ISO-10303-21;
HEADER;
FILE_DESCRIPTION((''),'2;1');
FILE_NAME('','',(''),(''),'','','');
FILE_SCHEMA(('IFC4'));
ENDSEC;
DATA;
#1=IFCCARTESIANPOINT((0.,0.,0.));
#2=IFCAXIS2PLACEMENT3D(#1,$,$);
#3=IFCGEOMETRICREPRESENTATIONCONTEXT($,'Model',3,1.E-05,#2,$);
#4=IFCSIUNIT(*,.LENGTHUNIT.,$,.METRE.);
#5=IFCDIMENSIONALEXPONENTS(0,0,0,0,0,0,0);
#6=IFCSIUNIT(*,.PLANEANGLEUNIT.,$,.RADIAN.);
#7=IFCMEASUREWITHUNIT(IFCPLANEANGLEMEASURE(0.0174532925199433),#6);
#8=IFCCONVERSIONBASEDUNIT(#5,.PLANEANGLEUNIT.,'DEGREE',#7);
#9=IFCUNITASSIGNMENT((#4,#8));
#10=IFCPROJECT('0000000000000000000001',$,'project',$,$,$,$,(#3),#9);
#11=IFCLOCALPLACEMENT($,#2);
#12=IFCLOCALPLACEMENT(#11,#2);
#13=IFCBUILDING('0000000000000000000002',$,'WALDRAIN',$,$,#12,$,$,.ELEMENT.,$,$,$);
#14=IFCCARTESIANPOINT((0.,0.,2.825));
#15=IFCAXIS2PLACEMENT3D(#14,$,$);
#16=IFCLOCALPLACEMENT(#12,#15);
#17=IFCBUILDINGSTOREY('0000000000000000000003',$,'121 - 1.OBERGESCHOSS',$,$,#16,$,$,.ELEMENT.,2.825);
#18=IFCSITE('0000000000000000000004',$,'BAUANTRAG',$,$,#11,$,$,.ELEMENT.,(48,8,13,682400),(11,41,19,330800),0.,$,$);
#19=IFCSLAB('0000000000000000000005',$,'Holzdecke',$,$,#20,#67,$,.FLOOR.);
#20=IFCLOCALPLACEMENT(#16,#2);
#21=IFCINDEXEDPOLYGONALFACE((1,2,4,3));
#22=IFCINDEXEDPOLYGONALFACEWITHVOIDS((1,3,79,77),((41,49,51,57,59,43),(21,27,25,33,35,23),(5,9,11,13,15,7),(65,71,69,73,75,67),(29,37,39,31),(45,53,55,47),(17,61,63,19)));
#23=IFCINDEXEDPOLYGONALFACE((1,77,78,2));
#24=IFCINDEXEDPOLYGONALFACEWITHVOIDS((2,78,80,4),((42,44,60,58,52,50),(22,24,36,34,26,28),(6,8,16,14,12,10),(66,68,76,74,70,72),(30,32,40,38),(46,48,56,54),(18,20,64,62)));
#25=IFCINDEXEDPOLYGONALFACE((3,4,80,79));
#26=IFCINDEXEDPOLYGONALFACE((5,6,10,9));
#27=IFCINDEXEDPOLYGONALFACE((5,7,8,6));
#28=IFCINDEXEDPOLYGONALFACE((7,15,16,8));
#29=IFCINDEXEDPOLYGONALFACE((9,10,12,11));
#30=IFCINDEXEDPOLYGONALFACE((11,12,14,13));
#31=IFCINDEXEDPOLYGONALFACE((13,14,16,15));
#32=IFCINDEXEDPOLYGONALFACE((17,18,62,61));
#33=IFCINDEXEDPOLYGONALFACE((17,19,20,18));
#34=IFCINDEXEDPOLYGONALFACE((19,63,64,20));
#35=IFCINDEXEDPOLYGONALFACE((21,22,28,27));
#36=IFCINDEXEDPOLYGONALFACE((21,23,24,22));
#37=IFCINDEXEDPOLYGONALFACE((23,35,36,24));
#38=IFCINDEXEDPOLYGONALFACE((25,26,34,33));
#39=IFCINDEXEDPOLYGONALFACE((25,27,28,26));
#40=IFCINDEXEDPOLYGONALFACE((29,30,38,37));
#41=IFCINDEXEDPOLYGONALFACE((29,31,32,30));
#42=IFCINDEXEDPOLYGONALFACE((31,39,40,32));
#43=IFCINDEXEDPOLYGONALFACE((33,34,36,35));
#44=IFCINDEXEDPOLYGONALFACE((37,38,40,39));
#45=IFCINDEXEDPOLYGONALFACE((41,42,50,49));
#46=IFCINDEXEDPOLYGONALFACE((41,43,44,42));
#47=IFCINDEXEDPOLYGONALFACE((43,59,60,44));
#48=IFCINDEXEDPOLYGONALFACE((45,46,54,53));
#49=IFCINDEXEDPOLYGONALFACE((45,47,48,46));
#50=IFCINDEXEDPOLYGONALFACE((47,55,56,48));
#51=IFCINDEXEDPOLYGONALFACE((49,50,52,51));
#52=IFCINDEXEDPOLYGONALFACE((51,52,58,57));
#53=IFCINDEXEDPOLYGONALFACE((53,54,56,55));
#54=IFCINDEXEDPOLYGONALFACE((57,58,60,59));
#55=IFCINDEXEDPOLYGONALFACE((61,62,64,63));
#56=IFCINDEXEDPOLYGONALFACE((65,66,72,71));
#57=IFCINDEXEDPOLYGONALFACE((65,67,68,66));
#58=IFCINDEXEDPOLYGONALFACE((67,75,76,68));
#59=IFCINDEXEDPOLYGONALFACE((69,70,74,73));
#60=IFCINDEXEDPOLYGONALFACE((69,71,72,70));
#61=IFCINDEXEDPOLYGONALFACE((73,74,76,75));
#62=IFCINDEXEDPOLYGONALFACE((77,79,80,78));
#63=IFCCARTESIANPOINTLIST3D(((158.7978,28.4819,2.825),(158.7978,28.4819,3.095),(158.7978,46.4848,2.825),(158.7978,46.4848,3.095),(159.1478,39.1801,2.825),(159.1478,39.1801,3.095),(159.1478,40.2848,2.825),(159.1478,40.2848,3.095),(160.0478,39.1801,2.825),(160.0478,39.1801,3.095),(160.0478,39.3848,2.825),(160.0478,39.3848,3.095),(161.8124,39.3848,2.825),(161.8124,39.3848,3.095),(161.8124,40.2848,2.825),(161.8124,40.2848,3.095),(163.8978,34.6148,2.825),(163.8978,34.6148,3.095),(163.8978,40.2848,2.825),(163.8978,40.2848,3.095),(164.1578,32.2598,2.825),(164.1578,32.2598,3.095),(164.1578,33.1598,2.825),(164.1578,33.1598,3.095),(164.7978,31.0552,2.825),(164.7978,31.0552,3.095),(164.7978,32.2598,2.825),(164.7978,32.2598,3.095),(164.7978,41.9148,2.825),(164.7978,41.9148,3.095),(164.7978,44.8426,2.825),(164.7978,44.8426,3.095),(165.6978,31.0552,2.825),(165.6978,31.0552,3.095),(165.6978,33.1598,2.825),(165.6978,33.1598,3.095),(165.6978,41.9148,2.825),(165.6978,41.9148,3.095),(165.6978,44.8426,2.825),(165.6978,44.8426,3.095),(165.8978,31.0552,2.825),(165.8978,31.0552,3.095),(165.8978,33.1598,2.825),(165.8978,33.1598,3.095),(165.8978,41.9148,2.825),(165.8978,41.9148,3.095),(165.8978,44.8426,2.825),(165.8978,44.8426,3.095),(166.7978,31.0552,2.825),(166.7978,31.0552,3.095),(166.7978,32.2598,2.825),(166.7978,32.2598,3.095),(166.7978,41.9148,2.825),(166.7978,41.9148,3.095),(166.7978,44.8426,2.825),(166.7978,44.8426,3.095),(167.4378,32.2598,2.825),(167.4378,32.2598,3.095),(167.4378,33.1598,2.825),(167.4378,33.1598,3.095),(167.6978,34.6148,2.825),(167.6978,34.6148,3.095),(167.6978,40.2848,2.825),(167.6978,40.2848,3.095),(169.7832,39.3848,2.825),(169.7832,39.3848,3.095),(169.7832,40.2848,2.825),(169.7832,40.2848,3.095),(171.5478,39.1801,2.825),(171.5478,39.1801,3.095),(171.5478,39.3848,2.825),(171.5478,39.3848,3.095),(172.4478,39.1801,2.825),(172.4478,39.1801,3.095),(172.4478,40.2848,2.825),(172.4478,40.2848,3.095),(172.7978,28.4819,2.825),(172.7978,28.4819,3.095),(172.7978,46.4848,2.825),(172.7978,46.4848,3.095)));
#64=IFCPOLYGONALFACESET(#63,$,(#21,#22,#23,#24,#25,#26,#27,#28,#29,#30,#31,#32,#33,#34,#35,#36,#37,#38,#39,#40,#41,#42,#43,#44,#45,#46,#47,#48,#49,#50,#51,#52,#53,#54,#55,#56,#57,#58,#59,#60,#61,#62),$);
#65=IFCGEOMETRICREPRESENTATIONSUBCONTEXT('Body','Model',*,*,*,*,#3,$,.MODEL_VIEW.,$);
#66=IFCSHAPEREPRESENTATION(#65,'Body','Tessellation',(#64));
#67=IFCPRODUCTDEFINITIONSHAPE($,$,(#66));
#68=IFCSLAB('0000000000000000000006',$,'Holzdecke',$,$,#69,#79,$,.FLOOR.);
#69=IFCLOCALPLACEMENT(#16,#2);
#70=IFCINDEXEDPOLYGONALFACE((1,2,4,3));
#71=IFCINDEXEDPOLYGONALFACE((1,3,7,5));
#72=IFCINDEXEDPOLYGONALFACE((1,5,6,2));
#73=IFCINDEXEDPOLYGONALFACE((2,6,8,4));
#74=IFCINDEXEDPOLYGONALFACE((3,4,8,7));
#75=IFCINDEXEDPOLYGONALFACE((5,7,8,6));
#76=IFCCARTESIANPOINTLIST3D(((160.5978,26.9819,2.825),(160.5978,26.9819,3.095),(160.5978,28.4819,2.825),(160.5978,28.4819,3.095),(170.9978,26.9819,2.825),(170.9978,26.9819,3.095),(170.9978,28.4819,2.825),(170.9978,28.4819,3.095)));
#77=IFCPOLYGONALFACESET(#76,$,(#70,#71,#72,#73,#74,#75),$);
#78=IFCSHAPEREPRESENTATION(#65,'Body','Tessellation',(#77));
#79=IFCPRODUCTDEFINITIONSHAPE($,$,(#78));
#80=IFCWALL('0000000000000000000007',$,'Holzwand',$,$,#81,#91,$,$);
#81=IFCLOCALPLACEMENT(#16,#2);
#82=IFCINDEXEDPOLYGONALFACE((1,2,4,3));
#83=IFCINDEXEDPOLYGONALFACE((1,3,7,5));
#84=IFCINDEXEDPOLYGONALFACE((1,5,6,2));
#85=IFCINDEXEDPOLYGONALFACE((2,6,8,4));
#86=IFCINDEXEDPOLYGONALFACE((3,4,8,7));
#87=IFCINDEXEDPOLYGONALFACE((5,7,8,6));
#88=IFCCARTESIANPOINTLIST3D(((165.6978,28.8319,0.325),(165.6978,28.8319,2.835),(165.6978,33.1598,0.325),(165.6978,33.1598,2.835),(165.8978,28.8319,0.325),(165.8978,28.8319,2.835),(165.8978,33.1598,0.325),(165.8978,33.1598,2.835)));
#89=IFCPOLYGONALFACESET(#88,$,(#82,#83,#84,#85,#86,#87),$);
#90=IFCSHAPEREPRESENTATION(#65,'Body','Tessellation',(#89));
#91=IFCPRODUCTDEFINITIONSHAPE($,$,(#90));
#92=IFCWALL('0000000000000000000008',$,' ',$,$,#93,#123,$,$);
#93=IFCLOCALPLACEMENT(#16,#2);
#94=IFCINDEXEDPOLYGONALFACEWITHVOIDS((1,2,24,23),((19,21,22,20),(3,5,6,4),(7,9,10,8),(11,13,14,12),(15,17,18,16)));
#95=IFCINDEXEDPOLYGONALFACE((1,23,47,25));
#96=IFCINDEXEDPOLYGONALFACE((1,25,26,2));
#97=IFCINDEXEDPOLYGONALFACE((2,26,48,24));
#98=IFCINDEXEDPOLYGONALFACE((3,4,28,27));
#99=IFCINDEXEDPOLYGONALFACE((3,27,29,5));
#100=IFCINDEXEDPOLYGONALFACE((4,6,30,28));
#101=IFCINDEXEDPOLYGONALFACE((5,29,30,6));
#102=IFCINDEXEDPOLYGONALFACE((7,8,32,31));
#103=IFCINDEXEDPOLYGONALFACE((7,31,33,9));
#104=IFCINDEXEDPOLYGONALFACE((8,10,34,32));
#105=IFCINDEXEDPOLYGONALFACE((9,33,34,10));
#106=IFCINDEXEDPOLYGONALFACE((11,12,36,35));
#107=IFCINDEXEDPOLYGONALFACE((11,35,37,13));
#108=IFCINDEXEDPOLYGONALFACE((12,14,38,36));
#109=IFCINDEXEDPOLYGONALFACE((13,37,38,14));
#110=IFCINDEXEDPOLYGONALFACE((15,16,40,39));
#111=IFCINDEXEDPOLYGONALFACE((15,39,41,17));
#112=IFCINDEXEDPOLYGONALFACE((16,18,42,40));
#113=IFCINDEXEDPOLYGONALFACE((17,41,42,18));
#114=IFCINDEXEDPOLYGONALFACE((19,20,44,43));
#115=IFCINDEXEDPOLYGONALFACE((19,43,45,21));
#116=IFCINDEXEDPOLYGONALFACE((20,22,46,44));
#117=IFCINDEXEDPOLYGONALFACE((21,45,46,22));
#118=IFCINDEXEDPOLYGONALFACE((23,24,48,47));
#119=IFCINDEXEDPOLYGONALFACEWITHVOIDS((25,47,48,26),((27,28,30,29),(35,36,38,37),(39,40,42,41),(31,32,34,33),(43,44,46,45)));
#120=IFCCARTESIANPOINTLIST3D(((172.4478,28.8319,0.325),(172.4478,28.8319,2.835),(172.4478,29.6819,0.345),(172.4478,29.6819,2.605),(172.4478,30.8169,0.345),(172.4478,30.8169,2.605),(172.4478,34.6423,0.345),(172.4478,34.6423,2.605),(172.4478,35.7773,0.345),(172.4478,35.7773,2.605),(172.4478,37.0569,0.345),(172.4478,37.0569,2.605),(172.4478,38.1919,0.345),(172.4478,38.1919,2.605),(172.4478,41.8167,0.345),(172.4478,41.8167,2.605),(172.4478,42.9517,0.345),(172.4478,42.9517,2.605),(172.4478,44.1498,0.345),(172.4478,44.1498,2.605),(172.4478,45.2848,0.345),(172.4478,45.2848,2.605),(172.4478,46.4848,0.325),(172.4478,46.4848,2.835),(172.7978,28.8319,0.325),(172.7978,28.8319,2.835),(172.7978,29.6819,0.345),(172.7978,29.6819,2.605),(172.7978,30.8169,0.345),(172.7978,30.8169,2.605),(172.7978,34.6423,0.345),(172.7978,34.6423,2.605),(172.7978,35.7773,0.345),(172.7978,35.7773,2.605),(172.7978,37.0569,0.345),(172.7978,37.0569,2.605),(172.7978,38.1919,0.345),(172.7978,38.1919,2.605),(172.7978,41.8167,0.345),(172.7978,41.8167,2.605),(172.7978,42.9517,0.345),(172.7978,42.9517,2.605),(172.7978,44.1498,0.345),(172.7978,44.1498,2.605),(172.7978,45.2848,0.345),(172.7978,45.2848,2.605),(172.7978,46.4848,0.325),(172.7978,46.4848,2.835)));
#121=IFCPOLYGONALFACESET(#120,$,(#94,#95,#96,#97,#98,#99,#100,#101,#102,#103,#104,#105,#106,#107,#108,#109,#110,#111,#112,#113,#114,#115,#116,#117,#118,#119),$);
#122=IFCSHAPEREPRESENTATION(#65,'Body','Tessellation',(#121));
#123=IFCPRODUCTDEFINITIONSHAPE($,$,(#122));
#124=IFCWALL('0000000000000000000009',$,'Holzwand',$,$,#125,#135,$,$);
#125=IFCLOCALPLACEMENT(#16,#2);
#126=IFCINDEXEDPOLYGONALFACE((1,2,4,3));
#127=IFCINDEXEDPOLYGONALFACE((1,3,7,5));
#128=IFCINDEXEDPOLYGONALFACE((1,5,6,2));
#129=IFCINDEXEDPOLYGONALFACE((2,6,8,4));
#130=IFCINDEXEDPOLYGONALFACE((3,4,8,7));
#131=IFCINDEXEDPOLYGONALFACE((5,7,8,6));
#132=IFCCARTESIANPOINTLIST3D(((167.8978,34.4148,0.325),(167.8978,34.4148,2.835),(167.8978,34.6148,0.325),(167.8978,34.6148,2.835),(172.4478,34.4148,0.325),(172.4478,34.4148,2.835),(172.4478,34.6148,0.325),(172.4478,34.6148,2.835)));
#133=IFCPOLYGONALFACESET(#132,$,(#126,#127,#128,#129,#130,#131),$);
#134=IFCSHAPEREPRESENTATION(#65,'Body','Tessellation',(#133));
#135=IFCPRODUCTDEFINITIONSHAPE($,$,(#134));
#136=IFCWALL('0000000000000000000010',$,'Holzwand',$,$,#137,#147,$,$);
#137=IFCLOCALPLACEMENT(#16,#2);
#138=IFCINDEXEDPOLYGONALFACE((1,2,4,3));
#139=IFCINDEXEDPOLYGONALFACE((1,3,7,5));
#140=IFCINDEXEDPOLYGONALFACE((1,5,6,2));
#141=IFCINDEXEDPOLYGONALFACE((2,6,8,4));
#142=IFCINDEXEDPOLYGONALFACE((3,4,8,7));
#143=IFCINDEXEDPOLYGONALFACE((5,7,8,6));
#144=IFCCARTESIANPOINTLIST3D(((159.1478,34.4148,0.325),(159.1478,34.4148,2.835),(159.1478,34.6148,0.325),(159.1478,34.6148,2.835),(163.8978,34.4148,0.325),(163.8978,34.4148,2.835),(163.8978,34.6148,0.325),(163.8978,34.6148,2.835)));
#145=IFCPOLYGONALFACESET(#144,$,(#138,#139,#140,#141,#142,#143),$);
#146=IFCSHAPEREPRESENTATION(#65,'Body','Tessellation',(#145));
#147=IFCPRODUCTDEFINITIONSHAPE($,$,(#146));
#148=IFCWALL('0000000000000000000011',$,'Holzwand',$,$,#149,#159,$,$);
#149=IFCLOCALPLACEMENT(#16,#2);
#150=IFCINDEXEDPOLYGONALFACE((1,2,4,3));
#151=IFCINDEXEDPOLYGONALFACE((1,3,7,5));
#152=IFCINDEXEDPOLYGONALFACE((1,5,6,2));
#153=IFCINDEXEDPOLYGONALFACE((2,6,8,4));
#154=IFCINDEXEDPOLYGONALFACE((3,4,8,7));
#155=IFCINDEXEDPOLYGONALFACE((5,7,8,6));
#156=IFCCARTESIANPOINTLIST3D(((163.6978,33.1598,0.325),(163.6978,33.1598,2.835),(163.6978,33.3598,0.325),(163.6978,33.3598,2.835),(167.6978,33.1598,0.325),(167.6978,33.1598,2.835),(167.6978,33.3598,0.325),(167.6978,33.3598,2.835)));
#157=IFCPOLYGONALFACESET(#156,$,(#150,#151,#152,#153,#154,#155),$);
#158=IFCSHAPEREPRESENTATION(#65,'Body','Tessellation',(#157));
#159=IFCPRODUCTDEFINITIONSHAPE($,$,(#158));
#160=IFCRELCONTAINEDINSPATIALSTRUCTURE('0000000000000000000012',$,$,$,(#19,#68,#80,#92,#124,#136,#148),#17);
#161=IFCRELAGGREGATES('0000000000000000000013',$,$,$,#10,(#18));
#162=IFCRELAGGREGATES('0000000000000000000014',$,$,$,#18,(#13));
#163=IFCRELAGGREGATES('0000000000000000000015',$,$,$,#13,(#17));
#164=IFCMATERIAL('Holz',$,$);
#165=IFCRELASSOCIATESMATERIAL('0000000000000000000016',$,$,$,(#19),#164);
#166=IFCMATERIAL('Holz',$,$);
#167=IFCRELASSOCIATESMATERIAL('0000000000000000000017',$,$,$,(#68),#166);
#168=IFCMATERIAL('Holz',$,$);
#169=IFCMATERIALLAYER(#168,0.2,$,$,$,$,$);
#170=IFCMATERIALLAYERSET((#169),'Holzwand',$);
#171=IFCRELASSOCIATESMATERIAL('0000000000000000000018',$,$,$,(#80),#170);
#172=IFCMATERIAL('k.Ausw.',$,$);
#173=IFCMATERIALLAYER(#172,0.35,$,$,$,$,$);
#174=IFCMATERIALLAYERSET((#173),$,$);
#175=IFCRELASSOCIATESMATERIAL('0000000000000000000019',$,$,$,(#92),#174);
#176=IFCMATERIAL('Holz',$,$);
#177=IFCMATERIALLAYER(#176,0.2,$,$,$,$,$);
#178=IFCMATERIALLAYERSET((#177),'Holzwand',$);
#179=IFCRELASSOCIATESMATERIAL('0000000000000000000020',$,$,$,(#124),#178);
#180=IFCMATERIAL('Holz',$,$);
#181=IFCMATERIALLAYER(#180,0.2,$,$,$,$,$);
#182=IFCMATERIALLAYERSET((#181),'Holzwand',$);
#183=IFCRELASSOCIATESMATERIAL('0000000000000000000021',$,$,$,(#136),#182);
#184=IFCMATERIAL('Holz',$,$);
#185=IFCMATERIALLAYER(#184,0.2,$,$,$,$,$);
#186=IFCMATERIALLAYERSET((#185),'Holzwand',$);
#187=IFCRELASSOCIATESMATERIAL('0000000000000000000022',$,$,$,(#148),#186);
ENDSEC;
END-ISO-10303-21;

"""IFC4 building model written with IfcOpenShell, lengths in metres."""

from ifc_helpers import new_model, entity, si_unit, converted_unit, frame, frame_2d, origin, origin_with_axes, place, context, subcontext, project, spatial, polyline, rectangle, outline, extrude, material, layer, layer_set, layer_usage, element, save


model = new_model("IFC4")

# Units and contexts
model_context = context("Model", 3, precision=1e-05, world=origin())
body_context = subcontext(model_context, "Body", "Model", "MODEL_VIEW")
ifc_project = project(units=[si_unit("LENGTHUNIT", "METRE"), converted_unit("PLANEANGLEUNIT", "DEGREE", entity("IfcPlaneAngleMeasure", 0.0174532925199433), si_unit("PLANEANGLEUNIT", "RADIAN"), dimensions=[0, 0, 0, 0, 0, 0, 0])], contexts=[model_context])

# Site, building, storey
site_placement = place(None, origin())
site = spatial("IfcSite", under=ifc_project, at=site_placement, Name="BAUANTRAG", CompositionType="ELEMENT", RefLatitude=(48, 8, 13, 682400), RefLongitude=(11, 41, 19, 330800), RefElevation=0.0)
building_placement = place(site_placement, origin())
building = spatial("IfcBuilding", under=site, at=building_placement, Name="WALDRAIN", CompositionType="ELEMENT")
storey_placement = place(building_placement, frame((0.0, 0.0, 2.825)))
storey = spatial("IfcBuildingStorey", under=building, at=storey_placement, Name="121 - 1.OBERGESCHOSS", CompositionType="ELEMENT", Elevation=2.825)

# Slab, opening
ifc_material_1 = material(Name="Holz")
slab_1_placement = place(storey_placement, frame((158.7978, 28.4819, 2.825)))
slab_1 = element("IfcSlab", 1, at=slab_1_placement, inside=storey, material=ifc_material_1, Name="Holzdecke", PredefinedType="FLOOR", context=body_context, shape_type="SweptSolid", body=[
    extrude(outline(polyline([(0.0, 0.0), (14.0, 0.0), (14.0, 18.0029), (0.0, 18.0029), (0.0, 0.0)]), holes=[polyline([(5.1, 6.1329), (5.1, 11.8029), (8.9, 11.8029), (8.9, 6.1329), (5.1, 6.1329)]), polyline([(6.9, 13.4329), (6.0, 13.4329), (6.0, 16.3607), (6.9, 16.3607), (6.9, 13.4329)]), polyline([(7.1, 16.3607), (8.0, 16.3607), (8.0, 13.4329), (7.1, 13.4329), (7.1, 16.3607)]), polyline([(12.75, 10.6981), (12.75, 10.9029), (10.9854, 10.9029), (10.9854, 11.8029), (13.65, 11.8029), (13.65, 10.6981), (12.75, 10.6981)]), polyline([(6.0, 3.7779), (5.36, 3.7779), (5.36, 4.6779), (6.9, 4.6779), (6.9, 2.5733), (6.0, 2.5733), (6.0, 3.7779)]), polyline([(7.1, 2.5733), (7.1, 4.6779), (8.64, 4.6779), (8.64, 3.7779), (8.0, 3.7779), (8.0, 2.5733), (7.1, 2.5733)])]), origin_with_axes(), (0.0, 0.0, 1.0), 0.27),
])
opening_1_placement = place(slab_1_placement, frame((0.35, 10.6981, 0.0)))
element("IfcOpeningElement", 2, at=opening_1_placement, cuts=slab_1, ObjectType="Opening", context=body_context, shape_type="SweptSolid", body=[
    extrude(outline(polyline([(1.4764, 0.6682), (-1.1882, 0.6682), (-1.1882, -0.4365), (-0.2882, -0.4365), (-0.2882, -0.2318), (1.4764, -0.2318), (1.4764, 0.6682)])), frame((1.1882, 0.4365, 0.0), z_axis=(0.0, 0.0, 1.0), x_axis=(1.0, 0.0, 0.0)), (0.0, 0.0, 1.0), 0.27),
])

# Slab
ifc_material_2 = material(Name="Holz")
slab_2_placement = place(storey_placement, frame((160.5978, 26.9819, 2.825)))
element("IfcSlab", 3, at=slab_2_placement, inside=storey, material=ifc_material_2, Name="Holzdecke", PredefinedType="FLOOR", context=body_context, shape_type="SweptSolid", body=[
    extrude(rectangle(XDim=10.4, YDim=1.5, at=frame_2d((5.2, 0.75), x_axis=(1.0, 0.0))), origin_with_axes(), (0.0, 0.0, 1.0), 0.27),
])

# Wall
ifc_material_3 = material(Name="Holz")
ifc_layer_1 = layer(ifc_material_3, 0.2)
ifc_layer_set_1 = layer_set([ifc_layer_1], Name="Holzwand")
ifc_layer_usage_1 = layer_usage(ifc_layer_set_1, "AXIS2", "POSITIVE", 0.0)
wall_1_placement = place(storey_placement, frame((165.6978, 33.1598, 0.325), z_axis=(0.0, 0.0, 1.0), x_axis=(0.0, -1.0, 0.0)))
element("IfcWall", 4, at=wall_1_placement, inside=storey, material=ifc_layer_usage_1, Name="Holzwand", context=body_context, shape_type="SweptSolid", body=[
    extrude(rectangle(XDim=4.3279, YDim=0.2, at=frame_2d((2.1639, 0.1), x_axis=(1.0, 0.0))), origin_with_axes(), (0.0, 0.0, 1.0), 2.51),
])

# Wall, openings
ifc_material_4 = material(Name="k.Ausw.")
ifc_layer_2 = layer(ifc_material_4, 0.35)
ifc_layer_set_2 = layer_set([ifc_layer_2])
ifc_layer_usage_2 = layer_usage(ifc_layer_set_2, "AXIS2", "POSITIVE", 0.0)
wall_2_placement = place(storey_placement, frame((172.7978, 28.8319, 0.325), z_axis=(0.0, 0.0, 1.0), x_axis=(0.0, 1.0, 0.0)))
wall_2 = element("IfcWall", 5, at=wall_2_placement, inside=storey, material=ifc_layer_usage_2, Name=" ", context=body_context, shape_type="SweptSolid", body=[
    extrude(rectangle(XDim=17.6529, YDim=0.35, at=frame_2d((8.8264, 0.175), x_axis=(1.0, 0.0))), origin_with_axes(), (0.0, 0.0, 1.0), 2.51),
])
opening_2_placement = place(wall_2_placement, frame((1.985, 0.35, 0.02), z_axis=(0.0, -1.0, 0.0), x_axis=(0.0, 0.0, 1.0)))
element("IfcOpeningElement", 6, at=opening_2_placement, cuts=wall_2, ObjectType="Opening", context=body_context, shape_type="SweptSolid", body=[
    extrude(outline(polyline([(0.0, 1.135), (2.26, 1.135), (2.26, 0.0), (0.0, 0.0), (0.0, 1.135)])), origin_with_axes(), (0.0, 0.0, 1.0), 0.35),
])
opening_3_placement = place(wall_2_placement, frame((9.36, 0.35, 0.02), z_axis=(0.0, -1.0, 0.0), x_axis=(0.0, 0.0, 1.0)))
element("IfcOpeningElement", 7, at=opening_3_placement, cuts=wall_2, ObjectType="Opening", context=body_context, shape_type="SweptSolid", body=[
    extrude(outline(polyline([(0.0, 1.135), (2.26, 1.135), (2.26, 0.0), (0.0, 0.0), (0.0, 1.135)])), origin_with_axes(), (0.0, 0.0, 1.0), 0.35),
])
opening_4_placement = place(wall_2_placement, frame((6.9454, 0.35, 0.02), z_axis=(0.0, -1.0, 0.0), x_axis=(0.0, 0.0, 1.0)))
element("IfcOpeningElement", 8, at=opening_4_placement, cuts=wall_2, ObjectType="Opening", context=body_context, shape_type="SweptSolid", body=[
    extrude(outline(polyline([(0.0, 1.135), (2.26, 1.135), (2.26, 0.0), (0.0, 0.0), (0.0, 1.135)])), origin_with_axes(), (0.0, 0.0, 1.0), 0.35),
])
opening_5_placement = place(wall_2_placement, frame((16.4529, 0.35, 0.02), z_axis=(0.0, -1.0, 0.0), x_axis=(0.0, 0.0, 1.0)))
element("IfcOpeningElement", 9, at=opening_5_placement, cuts=wall_2, ObjectType="Opening", context=body_context, shape_type="SweptSolid", body=[
    extrude(outline(polyline([(0.0, 1.135), (2.26, 1.135), (2.26, 0.0), (0.0, 0.0), (0.0, 1.135)])), origin_with_axes(), (0.0, 0.0, 1.0), 0.35),
])
opening_6_placement = place(wall_2_placement, frame((14.1198, 0.35, 0.02), z_axis=(0.0, -1.0, 0.0), x_axis=(0.0, 0.0, 1.0)))
element("IfcOpeningElement", 10, at=opening_6_placement, cuts=wall_2, ObjectType="Opening", context=body_context, shape_type="SweptSolid", body=[
    extrude(outline(polyline([(0.0, 1.135), (2.26, 1.135), (2.26, 0.0), (0.0, 0.0), (0.0, 1.135)])), origin_with_axes(), (0.0, 0.0, 1.0), 0.35),
])

# Walls
ifc_material_5 = material(Name="Holz")
ifc_layer_3 = layer(ifc_material_5, 0.2)
ifc_layer_set_3 = layer_set([ifc_layer_3], Name="Holzwand")
ifc_layer_usage_3 = layer_usage(ifc_layer_set_3, "AXIS2", "POSITIVE", 0.0)
wall_3_placement = place(storey_placement, frame((167.8978, 34.4148, 0.325)))
element("IfcWall", 11, at=wall_3_placement, inside=storey, material=ifc_layer_usage_3, Name="Holzwand", context=body_context, shape_type="SweptSolid", body=[
    extrude(rectangle(XDim=4.55, YDim=0.2, at=frame_2d((2.275, 0.1), x_axis=(1.0, 0.0))), origin_with_axes(), (0.0, 0.0, 1.0), 2.51),
])
ifc_material_6 = material(Name="Holz")
ifc_layer_4 = layer(ifc_material_6, 0.2)
ifc_layer_set_4 = layer_set([ifc_layer_4], Name="Holzwand")
ifc_layer_usage_4 = layer_usage(ifc_layer_set_4, "AXIS2", "POSITIVE", 0.0)
wall_4_placement = place(storey_placement, frame((159.1478, 34.4148, 0.325)))
element("IfcWall", 12, at=wall_4_placement, inside=storey, material=ifc_layer_usage_4, Name="Holzwand", context=body_context, shape_type="SweptSolid", body=[
    extrude(rectangle(XDim=4.75, YDim=0.2, at=frame_2d((2.375, 0.1), x_axis=(1.0, 0.0))), origin_with_axes(), (0.0, 0.0, 1.0), 2.51),
])
ifc_material_7 = material(Name="Holz")
ifc_layer_5 = layer(ifc_material_7, 0.2)
ifc_layer_set_5 = layer_set([ifc_layer_5], Name="Holzwand")
ifc_layer_usage_5 = layer_usage(ifc_layer_set_5, "AXIS2", "POSITIVE", 0.0)
wall_5_placement = place(storey_placement, frame((167.6978, 33.3598, 0.325), z_axis=(0.0, 0.0, 1.0), x_axis=(-1.0, 0.0, 0.0)))
element("IfcWall", 13, at=wall_5_placement, inside=storey, material=ifc_layer_usage_5, Name="Holzwand", context=body_context, shape_type="SweptSolid", body=[
    extrude(rectangle(XDim=4.0, YDim=0.2, at=frame_2d((2.0, 0.1), x_axis=(1.0, 0.0))), origin_with_axes(), (0.0, 0.0, 1.0), 2.51),
])

save(model, "model.ifc")
